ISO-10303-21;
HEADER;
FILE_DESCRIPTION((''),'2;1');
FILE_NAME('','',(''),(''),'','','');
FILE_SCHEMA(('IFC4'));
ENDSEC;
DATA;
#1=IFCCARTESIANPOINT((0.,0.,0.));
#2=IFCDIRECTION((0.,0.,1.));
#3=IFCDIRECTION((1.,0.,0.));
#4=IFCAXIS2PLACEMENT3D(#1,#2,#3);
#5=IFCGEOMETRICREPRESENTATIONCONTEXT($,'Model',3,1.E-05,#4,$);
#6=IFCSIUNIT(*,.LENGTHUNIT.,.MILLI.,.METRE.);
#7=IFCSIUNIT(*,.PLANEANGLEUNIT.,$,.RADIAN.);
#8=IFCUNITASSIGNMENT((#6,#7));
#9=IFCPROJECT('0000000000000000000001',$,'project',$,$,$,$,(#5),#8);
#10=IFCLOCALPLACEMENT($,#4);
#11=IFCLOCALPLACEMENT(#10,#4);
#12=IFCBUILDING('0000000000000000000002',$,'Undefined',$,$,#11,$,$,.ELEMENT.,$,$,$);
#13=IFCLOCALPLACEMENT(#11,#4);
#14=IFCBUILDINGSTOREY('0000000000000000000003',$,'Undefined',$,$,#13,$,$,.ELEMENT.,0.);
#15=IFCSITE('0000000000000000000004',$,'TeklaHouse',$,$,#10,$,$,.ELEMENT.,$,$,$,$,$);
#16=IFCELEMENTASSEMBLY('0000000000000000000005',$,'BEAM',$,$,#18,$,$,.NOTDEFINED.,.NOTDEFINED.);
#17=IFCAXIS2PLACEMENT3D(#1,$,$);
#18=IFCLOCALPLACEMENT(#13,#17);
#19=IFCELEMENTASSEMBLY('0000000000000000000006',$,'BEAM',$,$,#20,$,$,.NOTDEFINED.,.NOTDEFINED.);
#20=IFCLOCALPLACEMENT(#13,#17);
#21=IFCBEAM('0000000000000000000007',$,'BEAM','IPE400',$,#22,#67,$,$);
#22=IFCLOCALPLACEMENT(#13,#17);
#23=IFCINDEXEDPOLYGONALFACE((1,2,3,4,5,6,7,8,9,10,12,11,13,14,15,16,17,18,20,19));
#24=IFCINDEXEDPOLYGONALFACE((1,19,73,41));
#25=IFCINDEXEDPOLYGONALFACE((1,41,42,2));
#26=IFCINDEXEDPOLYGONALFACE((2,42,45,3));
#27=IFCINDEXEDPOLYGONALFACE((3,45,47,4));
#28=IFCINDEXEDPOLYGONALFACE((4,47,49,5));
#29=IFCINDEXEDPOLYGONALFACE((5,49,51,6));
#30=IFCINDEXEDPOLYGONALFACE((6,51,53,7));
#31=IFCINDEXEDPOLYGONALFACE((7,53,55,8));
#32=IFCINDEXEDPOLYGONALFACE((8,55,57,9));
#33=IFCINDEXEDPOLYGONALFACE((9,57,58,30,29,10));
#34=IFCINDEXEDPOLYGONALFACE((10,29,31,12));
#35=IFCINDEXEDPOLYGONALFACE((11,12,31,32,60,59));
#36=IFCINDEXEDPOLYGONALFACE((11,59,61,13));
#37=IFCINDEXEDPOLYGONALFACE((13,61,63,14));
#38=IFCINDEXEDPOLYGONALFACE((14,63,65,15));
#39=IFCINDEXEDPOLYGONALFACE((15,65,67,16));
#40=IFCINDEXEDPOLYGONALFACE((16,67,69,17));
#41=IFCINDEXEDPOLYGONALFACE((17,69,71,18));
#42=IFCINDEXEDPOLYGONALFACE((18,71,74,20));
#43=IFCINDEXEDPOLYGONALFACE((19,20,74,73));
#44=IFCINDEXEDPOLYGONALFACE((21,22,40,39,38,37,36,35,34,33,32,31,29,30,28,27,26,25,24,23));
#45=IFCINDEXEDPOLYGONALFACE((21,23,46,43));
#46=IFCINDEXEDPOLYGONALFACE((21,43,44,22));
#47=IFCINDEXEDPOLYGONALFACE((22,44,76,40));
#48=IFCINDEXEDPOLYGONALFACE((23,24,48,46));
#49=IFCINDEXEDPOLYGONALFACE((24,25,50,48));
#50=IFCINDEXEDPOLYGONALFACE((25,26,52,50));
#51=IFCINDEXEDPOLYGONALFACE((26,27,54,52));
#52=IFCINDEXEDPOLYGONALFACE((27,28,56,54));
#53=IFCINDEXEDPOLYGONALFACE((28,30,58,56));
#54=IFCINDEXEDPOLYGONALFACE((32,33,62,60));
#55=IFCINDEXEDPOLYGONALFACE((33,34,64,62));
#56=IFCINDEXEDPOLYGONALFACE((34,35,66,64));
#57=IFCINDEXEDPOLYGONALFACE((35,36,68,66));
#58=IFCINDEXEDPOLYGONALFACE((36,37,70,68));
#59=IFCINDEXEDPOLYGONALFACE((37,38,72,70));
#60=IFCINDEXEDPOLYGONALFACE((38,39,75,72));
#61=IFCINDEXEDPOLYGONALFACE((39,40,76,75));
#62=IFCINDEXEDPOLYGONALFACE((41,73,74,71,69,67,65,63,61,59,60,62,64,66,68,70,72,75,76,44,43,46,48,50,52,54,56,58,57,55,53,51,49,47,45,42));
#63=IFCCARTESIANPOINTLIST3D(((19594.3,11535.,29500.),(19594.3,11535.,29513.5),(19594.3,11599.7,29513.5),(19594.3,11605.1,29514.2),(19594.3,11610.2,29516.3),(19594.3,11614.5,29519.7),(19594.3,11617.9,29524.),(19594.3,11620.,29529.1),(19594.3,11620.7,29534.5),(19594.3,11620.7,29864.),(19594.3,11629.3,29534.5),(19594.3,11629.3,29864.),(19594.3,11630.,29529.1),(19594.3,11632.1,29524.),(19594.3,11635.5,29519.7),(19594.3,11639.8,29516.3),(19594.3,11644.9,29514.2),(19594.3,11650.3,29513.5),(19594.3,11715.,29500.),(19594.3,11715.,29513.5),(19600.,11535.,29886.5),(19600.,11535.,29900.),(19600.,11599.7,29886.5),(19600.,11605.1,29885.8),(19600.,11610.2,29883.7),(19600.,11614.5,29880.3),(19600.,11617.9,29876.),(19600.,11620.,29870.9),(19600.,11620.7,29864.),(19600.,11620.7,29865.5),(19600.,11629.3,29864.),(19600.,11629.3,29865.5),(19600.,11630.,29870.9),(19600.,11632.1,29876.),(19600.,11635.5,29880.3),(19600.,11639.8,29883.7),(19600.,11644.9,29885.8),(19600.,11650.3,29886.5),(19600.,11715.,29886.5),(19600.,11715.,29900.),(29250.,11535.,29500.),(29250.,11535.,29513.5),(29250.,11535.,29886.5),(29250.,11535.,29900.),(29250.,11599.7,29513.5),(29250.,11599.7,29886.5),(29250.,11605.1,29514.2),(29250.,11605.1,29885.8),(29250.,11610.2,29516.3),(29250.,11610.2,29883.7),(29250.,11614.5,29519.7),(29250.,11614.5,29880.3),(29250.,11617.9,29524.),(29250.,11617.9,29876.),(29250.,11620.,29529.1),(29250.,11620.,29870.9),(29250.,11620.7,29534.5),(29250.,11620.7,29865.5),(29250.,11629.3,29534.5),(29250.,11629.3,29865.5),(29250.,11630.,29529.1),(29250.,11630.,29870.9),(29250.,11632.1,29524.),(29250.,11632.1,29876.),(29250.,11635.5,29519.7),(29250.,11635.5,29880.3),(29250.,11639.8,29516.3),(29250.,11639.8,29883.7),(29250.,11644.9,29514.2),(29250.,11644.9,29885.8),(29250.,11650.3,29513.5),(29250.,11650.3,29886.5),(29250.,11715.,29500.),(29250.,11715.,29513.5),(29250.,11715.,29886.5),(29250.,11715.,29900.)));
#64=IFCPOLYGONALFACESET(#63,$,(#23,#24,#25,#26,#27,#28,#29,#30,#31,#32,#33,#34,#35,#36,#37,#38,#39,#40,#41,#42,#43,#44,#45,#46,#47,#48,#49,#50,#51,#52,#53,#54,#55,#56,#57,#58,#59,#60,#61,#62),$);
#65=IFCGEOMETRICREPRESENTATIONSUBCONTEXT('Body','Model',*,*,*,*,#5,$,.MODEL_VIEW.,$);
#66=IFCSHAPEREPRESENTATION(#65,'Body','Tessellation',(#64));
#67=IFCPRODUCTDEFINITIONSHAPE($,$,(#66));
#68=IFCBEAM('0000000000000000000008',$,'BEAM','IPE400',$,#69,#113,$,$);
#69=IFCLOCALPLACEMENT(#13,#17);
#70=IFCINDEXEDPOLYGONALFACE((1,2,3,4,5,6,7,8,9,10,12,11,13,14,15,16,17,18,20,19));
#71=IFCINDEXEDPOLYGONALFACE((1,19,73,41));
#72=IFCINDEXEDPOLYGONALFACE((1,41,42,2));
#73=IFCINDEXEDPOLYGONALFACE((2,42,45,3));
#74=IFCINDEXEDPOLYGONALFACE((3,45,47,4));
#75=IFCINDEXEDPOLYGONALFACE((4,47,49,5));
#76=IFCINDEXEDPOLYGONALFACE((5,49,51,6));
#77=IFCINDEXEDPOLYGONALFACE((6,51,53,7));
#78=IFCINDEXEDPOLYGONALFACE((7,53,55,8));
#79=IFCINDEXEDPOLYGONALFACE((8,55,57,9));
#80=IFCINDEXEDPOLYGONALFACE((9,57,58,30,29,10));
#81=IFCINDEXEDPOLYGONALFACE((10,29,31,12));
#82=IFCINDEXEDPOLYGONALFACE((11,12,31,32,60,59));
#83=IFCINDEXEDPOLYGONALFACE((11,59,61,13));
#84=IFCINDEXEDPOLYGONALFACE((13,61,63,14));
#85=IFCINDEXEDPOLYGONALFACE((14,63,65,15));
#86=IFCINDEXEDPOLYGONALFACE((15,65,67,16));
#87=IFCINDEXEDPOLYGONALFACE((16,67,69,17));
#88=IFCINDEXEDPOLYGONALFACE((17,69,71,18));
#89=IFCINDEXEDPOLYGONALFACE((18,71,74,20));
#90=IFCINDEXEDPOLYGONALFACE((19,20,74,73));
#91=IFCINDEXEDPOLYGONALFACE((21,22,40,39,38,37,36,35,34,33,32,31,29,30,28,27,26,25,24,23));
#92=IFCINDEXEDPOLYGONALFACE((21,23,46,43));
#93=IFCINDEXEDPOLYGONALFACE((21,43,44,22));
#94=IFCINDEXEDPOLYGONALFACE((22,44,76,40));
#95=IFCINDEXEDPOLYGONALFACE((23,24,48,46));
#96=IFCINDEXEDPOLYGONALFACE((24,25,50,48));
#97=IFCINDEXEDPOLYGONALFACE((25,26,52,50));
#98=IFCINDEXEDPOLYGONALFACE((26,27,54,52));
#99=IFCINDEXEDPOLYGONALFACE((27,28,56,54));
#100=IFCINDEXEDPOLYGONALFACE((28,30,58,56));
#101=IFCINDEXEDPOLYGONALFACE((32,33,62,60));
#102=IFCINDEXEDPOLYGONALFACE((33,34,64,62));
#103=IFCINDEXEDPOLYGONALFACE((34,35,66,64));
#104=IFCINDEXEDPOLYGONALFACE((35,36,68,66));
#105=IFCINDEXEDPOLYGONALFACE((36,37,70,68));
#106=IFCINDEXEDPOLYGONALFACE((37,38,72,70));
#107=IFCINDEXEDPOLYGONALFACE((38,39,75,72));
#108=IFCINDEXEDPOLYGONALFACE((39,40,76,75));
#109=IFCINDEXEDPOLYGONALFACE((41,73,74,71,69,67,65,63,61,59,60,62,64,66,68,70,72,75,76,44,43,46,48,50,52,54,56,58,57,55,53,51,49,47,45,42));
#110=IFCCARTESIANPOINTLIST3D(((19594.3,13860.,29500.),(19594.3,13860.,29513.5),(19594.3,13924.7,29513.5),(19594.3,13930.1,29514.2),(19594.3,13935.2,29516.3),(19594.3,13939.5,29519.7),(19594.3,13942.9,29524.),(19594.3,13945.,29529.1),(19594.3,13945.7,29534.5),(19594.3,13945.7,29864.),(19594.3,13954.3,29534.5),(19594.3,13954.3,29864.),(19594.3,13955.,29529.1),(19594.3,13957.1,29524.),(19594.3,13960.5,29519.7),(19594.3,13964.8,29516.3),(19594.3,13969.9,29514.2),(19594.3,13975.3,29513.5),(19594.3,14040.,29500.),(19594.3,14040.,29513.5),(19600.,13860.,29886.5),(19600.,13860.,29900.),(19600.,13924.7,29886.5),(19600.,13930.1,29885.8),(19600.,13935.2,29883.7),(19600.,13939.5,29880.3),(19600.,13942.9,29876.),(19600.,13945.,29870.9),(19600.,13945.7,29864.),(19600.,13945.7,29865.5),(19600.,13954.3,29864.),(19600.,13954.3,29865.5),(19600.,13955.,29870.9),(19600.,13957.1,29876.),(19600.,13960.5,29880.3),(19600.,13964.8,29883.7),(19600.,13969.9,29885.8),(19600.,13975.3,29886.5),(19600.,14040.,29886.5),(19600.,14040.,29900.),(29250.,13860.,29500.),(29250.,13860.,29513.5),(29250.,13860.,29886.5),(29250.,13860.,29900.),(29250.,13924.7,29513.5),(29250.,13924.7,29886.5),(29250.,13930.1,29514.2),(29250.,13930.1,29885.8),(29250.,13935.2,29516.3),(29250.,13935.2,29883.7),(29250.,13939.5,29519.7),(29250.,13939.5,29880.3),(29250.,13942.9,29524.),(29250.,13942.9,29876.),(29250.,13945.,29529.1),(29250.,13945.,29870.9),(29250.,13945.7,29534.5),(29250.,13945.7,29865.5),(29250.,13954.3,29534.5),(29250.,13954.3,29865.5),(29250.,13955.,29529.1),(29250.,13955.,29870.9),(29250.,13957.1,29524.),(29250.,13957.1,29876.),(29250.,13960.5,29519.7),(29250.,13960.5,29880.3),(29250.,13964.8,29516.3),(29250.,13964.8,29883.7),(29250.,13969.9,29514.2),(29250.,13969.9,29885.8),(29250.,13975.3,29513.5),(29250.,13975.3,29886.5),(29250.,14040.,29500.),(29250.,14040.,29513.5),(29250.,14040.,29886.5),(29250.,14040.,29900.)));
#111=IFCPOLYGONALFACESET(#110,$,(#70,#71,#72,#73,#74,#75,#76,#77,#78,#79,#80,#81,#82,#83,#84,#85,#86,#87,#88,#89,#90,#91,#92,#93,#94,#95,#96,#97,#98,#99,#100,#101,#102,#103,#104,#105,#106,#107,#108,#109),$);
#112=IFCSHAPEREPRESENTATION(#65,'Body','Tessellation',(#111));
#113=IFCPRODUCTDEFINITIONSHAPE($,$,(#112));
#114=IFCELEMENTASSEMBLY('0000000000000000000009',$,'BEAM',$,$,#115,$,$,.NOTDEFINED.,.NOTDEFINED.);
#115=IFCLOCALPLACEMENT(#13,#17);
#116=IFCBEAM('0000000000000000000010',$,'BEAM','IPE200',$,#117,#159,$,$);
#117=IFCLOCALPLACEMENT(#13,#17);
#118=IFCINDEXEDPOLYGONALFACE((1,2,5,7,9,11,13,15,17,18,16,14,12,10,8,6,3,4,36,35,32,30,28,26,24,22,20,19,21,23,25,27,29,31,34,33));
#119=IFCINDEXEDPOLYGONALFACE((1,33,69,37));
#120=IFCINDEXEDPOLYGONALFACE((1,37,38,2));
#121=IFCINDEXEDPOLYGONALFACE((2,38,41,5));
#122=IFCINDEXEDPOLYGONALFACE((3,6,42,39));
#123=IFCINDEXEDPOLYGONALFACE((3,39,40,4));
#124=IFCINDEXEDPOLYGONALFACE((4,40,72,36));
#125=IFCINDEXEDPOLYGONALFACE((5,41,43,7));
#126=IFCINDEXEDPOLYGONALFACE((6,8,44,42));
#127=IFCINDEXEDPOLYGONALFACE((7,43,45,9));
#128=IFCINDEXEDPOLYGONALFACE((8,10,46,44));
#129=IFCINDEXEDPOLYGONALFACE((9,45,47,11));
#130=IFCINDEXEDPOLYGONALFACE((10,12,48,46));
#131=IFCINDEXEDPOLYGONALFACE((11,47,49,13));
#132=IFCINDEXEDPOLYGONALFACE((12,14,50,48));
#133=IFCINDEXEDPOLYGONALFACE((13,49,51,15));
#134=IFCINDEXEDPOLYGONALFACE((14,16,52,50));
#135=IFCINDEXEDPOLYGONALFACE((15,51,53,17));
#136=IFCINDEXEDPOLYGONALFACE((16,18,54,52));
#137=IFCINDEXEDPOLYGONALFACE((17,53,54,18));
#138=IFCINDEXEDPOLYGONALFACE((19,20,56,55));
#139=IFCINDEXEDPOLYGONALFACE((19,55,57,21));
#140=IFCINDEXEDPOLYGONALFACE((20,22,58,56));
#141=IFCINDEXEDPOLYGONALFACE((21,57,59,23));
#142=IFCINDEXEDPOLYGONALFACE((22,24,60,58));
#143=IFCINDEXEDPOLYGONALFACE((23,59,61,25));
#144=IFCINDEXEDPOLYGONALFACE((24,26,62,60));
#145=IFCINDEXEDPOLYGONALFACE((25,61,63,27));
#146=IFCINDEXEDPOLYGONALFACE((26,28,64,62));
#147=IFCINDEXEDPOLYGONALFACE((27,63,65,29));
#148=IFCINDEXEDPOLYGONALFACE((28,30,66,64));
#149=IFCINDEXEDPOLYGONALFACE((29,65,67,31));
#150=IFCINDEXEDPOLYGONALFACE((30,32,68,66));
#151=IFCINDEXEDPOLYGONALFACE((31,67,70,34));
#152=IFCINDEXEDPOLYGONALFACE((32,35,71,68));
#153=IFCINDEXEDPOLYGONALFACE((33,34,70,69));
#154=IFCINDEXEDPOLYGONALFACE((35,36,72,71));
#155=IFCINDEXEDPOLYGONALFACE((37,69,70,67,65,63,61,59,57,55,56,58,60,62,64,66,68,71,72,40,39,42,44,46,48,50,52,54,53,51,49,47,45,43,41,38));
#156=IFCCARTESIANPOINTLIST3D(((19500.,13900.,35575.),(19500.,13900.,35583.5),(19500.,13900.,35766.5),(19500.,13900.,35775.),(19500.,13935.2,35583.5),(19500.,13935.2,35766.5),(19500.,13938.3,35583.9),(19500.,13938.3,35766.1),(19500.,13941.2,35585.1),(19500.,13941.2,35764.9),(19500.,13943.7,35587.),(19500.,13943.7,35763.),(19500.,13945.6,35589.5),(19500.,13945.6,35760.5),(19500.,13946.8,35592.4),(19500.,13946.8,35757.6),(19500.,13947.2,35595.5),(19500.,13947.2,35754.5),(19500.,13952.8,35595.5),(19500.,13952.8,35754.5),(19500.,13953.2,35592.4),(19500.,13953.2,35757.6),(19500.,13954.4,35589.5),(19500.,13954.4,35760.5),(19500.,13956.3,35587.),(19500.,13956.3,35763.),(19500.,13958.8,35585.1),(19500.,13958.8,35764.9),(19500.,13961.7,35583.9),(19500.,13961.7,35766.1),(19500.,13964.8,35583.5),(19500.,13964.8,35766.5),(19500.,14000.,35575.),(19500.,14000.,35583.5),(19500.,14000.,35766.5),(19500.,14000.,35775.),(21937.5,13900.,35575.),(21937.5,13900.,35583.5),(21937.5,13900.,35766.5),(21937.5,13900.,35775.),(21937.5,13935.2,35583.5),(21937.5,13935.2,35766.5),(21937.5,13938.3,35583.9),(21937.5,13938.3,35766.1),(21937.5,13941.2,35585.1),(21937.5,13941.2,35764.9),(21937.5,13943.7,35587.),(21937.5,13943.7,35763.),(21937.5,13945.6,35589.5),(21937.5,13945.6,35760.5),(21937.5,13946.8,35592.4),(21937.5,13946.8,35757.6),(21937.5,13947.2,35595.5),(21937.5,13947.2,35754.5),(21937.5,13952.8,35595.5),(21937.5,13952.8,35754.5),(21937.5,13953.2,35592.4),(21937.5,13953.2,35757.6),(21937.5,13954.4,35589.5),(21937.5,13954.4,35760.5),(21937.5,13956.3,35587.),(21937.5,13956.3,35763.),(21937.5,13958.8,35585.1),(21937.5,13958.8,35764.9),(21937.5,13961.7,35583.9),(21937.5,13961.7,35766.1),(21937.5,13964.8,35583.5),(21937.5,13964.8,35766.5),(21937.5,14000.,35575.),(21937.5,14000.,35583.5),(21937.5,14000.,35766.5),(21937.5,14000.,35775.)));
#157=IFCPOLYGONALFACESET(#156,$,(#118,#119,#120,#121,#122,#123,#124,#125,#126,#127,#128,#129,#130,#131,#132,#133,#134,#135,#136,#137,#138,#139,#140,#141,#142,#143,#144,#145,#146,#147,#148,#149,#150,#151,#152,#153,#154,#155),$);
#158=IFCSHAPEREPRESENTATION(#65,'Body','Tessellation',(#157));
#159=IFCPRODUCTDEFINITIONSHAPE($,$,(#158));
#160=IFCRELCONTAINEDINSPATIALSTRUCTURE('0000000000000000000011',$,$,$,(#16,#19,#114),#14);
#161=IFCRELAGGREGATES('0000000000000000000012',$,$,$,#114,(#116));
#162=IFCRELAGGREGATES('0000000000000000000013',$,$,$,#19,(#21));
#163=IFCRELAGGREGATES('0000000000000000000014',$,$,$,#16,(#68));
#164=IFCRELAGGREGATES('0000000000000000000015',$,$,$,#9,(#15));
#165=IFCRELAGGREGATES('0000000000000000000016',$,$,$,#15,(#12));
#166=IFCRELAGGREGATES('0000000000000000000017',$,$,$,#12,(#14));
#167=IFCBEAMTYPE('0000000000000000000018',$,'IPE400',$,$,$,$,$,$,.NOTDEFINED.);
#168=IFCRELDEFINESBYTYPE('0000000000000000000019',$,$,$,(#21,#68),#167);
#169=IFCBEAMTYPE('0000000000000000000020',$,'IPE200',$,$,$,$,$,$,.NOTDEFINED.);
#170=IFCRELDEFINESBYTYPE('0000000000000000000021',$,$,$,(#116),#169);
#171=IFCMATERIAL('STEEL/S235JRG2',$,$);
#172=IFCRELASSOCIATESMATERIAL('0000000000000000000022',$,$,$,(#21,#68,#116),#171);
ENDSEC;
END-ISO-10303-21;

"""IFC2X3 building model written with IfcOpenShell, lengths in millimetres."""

from ifc_helpers import new_model, si_unit, frame, origin_with_axes, origin_2d_with_axis, place, context, subcontext, project, spatial, polyline, i_section, outline, extrude, boolean, halfspace, material, type_object, element, aggregate, save


model = new_model("IFC2X3")

# Units and contexts
model_context = context("Model", 3, precision=1e-05, world=origin_with_axes())
body_context = subcontext(model_context, "Body", "Model", "MODEL_VIEW")
ifc_project = project(units=[si_unit("LENGTHUNIT", "METRE", prefix="MILLI"), si_unit("PLANEANGLEUNIT", "RADIAN")], contexts=[model_context])

# Site, building, storey
site_placement = place(None, origin_with_axes())
site = spatial("IfcSite", under=ifc_project, at=site_placement, Name="TeklaHouse", CompositionType="ELEMENT")
building_placement = place(site_placement, origin_with_axes())
building = spatial("IfcBuilding", under=site, at=building_placement, Name="Undefined", CompositionType="ELEMENT")
storey_placement = place(building_placement, origin_with_axes())
storey = spatial("IfcBuildingStorey", under=building, at=storey_placement, Name="Undefined", CompositionType="ELEMENT", Elevation=0.0)

# Shared definitions
ifc_material_1 = material(Name="STEEL/S235JRG2")

# Element assembly
assembly_1_placement = place(storey_placement, origin_with_axes())
assembly_1 = element("IfcElementAssembly", 1, at=assembly_1_placement, inside=storey, Name="BEAM", AssemblyPlace="NOTDEFINED", PredefinedType="NOTDEFINED")
beam_type_1 = type_object("IfcBeamType", Name="IPE400", PredefinedType="NOTDEFINED")

# Element assembly, beam
assembly_2_placement = place(storey_placement, origin_with_axes())
assembly_2 = element("IfcElementAssembly", 2, at=assembly_2_placement, inside=storey, Name="BEAM", AssemblyPlace="NOTDEFINED", PredefinedType="NOTDEFINED")
beam_1_placement = place(assembly_2_placement, frame((19500.0, 11625.0, 29700.0), z_axis=(0.0, 0.0, 1.0), x_axis=(1.0, 0.0, 0.0)))
beam_1 = element("IfcBeam", 3, at=beam_1_placement, type_object=beam_type_1, material=ifc_material_1, Name="BEAM", Description="IPE400", context=body_context, shape_type="CSG", body=[
    boolean("DIFFERENCE", boolean("DIFFERENCE", boolean("DIFFERENCE", extrude(i_section(OverallWidth=180.0, OverallDepth=400.0, WebThickness=8.6, FlangeThickness=13.5, FilletRadius=21.0, at=origin_2d_with_axis()), frame((9750.0, 0.0, 0.0), z_axis=(-1.0, 0.0, 0.0), x_axis=(0.0, -1.0, 0.0)), (0.0, 0.0, 1.0), 9750.0), extrude(outline(polyline([(0.0, 0.0), (95.7, 0.0), (95.7, 23.5), (0.0, 23.5), (0.0, 0.0)])), frame((-5.7, -100.0, -186.5), z_axis=(0.0, 1.0, 0.0), x_axis=(1.0, 0.0, 0.0)), (0.0, 0.0, 1.0), 200.0)), extrude(outline(polyline([(0.0, 0.0), (105.7, 0.0), (105.7, 46.0), (0.0, 46.0), (0.0, 0.0)])), frame((-5.7, 100.0, 164.0), z_axis=(0.0, -1.0, 0.0), x_axis=(1.0, 0.0, 0.0)), (0.0, 0.0, 1.0), 200.0)), halfspace(frame((94.3, 0.0, 0.0), z_axis=(1.0, 0.0, 0.0), x_axis=(0.0, -1.0, 0.0)), True)),
])

# Beam
beam_2_placement = place(assembly_1_placement, frame((19500.0, 13950.0, 29700.0), z_axis=(0.0, 0.0, 1.0), x_axis=(1.0, 0.0, 0.0)))
beam_2 = element("IfcBeam", 4, at=beam_2_placement, type_object=beam_type_1, material=ifc_material_1, Name="BEAM", Description="IPE400", context=body_context, shape_type="CSG", body=[
    boolean("DIFFERENCE", boolean("DIFFERENCE", boolean("DIFFERENCE", extrude(i_section(OverallWidth=180.0, OverallDepth=400.0, WebThickness=8.6, FlangeThickness=13.5, FilletRadius=21.0, at=origin_2d_with_axis()), frame((9750.0, 0.0, 0.0), z_axis=(-1.0, 0.0, 0.0), x_axis=(0.0, -1.0, 0.0)), (0.0, 0.0, 1.0), 9750.0), extrude(outline(polyline([(0.0, 0.0), (95.7, 0.0), (95.7, 23.5), (0.0, 23.5), (0.0, 0.0)])), frame((-5.7, -100.0, -186.5), z_axis=(0.0, 1.0, 0.0), x_axis=(1.0, 0.0, 0.0)), (0.0, 0.0, 1.0), 200.0)), extrude(outline(polyline([(0.0, 0.0), (105.7, 0.0), (105.7, 46.0), (0.0, 46.0), (0.0, 0.0)])), frame((-5.7, 100.0, 164.0), z_axis=(0.0, -1.0, 0.0), x_axis=(1.0, 0.0, 0.0)), (0.0, 0.0, 1.0), 200.0)), halfspace(frame((94.3, 0.0, 0.0), z_axis=(1.0, 0.0, 0.0), x_axis=(0.0, -1.0, 0.0)), True)),
])

# Element assembly, beam
assembly_3_placement = place(storey_placement, origin_with_axes())
assembly_3 = element("IfcElementAssembly", 5, at=assembly_3_placement, inside=storey, Name="BEAM", AssemblyPlace="NOTDEFINED", PredefinedType="NOTDEFINED")
beam_type_2 = type_object("IfcBeamType", Name="IPE200", PredefinedType="NOTDEFINED")
beam_3_placement = place(assembly_3_placement, frame((19500.0, 13950.0, 35675.0), z_axis=(0.0, 0.0, 1.0), x_axis=(1.0, 0.0, 0.0)))
beam_3 = element("IfcBeam", 6, at=beam_3_placement, type_object=beam_type_2, material=ifc_material_1, Name="BEAM", Description="IPE200", context=body_context, shape_type="SweptSolid", body=[
    extrude(i_section(OverallWidth=100.0, OverallDepth=200.0, WebThickness=5.6, FlangeThickness=8.5, FilletRadius=12.0, at=origin_2d_with_axis()), frame((2437.5, 0.0, 0.0), z_axis=(-1.0, 0.0, 0.0), x_axis=(0.0, -1.0, 0.0)), (0.0, 0.0, 1.0), 2437.5),
])
aggregate(assembly_3, [beam_3])

aggregate(assembly_2, [beam_1])
aggregate(assembly_1, [beam_2])

save(model, "model.ifc")
